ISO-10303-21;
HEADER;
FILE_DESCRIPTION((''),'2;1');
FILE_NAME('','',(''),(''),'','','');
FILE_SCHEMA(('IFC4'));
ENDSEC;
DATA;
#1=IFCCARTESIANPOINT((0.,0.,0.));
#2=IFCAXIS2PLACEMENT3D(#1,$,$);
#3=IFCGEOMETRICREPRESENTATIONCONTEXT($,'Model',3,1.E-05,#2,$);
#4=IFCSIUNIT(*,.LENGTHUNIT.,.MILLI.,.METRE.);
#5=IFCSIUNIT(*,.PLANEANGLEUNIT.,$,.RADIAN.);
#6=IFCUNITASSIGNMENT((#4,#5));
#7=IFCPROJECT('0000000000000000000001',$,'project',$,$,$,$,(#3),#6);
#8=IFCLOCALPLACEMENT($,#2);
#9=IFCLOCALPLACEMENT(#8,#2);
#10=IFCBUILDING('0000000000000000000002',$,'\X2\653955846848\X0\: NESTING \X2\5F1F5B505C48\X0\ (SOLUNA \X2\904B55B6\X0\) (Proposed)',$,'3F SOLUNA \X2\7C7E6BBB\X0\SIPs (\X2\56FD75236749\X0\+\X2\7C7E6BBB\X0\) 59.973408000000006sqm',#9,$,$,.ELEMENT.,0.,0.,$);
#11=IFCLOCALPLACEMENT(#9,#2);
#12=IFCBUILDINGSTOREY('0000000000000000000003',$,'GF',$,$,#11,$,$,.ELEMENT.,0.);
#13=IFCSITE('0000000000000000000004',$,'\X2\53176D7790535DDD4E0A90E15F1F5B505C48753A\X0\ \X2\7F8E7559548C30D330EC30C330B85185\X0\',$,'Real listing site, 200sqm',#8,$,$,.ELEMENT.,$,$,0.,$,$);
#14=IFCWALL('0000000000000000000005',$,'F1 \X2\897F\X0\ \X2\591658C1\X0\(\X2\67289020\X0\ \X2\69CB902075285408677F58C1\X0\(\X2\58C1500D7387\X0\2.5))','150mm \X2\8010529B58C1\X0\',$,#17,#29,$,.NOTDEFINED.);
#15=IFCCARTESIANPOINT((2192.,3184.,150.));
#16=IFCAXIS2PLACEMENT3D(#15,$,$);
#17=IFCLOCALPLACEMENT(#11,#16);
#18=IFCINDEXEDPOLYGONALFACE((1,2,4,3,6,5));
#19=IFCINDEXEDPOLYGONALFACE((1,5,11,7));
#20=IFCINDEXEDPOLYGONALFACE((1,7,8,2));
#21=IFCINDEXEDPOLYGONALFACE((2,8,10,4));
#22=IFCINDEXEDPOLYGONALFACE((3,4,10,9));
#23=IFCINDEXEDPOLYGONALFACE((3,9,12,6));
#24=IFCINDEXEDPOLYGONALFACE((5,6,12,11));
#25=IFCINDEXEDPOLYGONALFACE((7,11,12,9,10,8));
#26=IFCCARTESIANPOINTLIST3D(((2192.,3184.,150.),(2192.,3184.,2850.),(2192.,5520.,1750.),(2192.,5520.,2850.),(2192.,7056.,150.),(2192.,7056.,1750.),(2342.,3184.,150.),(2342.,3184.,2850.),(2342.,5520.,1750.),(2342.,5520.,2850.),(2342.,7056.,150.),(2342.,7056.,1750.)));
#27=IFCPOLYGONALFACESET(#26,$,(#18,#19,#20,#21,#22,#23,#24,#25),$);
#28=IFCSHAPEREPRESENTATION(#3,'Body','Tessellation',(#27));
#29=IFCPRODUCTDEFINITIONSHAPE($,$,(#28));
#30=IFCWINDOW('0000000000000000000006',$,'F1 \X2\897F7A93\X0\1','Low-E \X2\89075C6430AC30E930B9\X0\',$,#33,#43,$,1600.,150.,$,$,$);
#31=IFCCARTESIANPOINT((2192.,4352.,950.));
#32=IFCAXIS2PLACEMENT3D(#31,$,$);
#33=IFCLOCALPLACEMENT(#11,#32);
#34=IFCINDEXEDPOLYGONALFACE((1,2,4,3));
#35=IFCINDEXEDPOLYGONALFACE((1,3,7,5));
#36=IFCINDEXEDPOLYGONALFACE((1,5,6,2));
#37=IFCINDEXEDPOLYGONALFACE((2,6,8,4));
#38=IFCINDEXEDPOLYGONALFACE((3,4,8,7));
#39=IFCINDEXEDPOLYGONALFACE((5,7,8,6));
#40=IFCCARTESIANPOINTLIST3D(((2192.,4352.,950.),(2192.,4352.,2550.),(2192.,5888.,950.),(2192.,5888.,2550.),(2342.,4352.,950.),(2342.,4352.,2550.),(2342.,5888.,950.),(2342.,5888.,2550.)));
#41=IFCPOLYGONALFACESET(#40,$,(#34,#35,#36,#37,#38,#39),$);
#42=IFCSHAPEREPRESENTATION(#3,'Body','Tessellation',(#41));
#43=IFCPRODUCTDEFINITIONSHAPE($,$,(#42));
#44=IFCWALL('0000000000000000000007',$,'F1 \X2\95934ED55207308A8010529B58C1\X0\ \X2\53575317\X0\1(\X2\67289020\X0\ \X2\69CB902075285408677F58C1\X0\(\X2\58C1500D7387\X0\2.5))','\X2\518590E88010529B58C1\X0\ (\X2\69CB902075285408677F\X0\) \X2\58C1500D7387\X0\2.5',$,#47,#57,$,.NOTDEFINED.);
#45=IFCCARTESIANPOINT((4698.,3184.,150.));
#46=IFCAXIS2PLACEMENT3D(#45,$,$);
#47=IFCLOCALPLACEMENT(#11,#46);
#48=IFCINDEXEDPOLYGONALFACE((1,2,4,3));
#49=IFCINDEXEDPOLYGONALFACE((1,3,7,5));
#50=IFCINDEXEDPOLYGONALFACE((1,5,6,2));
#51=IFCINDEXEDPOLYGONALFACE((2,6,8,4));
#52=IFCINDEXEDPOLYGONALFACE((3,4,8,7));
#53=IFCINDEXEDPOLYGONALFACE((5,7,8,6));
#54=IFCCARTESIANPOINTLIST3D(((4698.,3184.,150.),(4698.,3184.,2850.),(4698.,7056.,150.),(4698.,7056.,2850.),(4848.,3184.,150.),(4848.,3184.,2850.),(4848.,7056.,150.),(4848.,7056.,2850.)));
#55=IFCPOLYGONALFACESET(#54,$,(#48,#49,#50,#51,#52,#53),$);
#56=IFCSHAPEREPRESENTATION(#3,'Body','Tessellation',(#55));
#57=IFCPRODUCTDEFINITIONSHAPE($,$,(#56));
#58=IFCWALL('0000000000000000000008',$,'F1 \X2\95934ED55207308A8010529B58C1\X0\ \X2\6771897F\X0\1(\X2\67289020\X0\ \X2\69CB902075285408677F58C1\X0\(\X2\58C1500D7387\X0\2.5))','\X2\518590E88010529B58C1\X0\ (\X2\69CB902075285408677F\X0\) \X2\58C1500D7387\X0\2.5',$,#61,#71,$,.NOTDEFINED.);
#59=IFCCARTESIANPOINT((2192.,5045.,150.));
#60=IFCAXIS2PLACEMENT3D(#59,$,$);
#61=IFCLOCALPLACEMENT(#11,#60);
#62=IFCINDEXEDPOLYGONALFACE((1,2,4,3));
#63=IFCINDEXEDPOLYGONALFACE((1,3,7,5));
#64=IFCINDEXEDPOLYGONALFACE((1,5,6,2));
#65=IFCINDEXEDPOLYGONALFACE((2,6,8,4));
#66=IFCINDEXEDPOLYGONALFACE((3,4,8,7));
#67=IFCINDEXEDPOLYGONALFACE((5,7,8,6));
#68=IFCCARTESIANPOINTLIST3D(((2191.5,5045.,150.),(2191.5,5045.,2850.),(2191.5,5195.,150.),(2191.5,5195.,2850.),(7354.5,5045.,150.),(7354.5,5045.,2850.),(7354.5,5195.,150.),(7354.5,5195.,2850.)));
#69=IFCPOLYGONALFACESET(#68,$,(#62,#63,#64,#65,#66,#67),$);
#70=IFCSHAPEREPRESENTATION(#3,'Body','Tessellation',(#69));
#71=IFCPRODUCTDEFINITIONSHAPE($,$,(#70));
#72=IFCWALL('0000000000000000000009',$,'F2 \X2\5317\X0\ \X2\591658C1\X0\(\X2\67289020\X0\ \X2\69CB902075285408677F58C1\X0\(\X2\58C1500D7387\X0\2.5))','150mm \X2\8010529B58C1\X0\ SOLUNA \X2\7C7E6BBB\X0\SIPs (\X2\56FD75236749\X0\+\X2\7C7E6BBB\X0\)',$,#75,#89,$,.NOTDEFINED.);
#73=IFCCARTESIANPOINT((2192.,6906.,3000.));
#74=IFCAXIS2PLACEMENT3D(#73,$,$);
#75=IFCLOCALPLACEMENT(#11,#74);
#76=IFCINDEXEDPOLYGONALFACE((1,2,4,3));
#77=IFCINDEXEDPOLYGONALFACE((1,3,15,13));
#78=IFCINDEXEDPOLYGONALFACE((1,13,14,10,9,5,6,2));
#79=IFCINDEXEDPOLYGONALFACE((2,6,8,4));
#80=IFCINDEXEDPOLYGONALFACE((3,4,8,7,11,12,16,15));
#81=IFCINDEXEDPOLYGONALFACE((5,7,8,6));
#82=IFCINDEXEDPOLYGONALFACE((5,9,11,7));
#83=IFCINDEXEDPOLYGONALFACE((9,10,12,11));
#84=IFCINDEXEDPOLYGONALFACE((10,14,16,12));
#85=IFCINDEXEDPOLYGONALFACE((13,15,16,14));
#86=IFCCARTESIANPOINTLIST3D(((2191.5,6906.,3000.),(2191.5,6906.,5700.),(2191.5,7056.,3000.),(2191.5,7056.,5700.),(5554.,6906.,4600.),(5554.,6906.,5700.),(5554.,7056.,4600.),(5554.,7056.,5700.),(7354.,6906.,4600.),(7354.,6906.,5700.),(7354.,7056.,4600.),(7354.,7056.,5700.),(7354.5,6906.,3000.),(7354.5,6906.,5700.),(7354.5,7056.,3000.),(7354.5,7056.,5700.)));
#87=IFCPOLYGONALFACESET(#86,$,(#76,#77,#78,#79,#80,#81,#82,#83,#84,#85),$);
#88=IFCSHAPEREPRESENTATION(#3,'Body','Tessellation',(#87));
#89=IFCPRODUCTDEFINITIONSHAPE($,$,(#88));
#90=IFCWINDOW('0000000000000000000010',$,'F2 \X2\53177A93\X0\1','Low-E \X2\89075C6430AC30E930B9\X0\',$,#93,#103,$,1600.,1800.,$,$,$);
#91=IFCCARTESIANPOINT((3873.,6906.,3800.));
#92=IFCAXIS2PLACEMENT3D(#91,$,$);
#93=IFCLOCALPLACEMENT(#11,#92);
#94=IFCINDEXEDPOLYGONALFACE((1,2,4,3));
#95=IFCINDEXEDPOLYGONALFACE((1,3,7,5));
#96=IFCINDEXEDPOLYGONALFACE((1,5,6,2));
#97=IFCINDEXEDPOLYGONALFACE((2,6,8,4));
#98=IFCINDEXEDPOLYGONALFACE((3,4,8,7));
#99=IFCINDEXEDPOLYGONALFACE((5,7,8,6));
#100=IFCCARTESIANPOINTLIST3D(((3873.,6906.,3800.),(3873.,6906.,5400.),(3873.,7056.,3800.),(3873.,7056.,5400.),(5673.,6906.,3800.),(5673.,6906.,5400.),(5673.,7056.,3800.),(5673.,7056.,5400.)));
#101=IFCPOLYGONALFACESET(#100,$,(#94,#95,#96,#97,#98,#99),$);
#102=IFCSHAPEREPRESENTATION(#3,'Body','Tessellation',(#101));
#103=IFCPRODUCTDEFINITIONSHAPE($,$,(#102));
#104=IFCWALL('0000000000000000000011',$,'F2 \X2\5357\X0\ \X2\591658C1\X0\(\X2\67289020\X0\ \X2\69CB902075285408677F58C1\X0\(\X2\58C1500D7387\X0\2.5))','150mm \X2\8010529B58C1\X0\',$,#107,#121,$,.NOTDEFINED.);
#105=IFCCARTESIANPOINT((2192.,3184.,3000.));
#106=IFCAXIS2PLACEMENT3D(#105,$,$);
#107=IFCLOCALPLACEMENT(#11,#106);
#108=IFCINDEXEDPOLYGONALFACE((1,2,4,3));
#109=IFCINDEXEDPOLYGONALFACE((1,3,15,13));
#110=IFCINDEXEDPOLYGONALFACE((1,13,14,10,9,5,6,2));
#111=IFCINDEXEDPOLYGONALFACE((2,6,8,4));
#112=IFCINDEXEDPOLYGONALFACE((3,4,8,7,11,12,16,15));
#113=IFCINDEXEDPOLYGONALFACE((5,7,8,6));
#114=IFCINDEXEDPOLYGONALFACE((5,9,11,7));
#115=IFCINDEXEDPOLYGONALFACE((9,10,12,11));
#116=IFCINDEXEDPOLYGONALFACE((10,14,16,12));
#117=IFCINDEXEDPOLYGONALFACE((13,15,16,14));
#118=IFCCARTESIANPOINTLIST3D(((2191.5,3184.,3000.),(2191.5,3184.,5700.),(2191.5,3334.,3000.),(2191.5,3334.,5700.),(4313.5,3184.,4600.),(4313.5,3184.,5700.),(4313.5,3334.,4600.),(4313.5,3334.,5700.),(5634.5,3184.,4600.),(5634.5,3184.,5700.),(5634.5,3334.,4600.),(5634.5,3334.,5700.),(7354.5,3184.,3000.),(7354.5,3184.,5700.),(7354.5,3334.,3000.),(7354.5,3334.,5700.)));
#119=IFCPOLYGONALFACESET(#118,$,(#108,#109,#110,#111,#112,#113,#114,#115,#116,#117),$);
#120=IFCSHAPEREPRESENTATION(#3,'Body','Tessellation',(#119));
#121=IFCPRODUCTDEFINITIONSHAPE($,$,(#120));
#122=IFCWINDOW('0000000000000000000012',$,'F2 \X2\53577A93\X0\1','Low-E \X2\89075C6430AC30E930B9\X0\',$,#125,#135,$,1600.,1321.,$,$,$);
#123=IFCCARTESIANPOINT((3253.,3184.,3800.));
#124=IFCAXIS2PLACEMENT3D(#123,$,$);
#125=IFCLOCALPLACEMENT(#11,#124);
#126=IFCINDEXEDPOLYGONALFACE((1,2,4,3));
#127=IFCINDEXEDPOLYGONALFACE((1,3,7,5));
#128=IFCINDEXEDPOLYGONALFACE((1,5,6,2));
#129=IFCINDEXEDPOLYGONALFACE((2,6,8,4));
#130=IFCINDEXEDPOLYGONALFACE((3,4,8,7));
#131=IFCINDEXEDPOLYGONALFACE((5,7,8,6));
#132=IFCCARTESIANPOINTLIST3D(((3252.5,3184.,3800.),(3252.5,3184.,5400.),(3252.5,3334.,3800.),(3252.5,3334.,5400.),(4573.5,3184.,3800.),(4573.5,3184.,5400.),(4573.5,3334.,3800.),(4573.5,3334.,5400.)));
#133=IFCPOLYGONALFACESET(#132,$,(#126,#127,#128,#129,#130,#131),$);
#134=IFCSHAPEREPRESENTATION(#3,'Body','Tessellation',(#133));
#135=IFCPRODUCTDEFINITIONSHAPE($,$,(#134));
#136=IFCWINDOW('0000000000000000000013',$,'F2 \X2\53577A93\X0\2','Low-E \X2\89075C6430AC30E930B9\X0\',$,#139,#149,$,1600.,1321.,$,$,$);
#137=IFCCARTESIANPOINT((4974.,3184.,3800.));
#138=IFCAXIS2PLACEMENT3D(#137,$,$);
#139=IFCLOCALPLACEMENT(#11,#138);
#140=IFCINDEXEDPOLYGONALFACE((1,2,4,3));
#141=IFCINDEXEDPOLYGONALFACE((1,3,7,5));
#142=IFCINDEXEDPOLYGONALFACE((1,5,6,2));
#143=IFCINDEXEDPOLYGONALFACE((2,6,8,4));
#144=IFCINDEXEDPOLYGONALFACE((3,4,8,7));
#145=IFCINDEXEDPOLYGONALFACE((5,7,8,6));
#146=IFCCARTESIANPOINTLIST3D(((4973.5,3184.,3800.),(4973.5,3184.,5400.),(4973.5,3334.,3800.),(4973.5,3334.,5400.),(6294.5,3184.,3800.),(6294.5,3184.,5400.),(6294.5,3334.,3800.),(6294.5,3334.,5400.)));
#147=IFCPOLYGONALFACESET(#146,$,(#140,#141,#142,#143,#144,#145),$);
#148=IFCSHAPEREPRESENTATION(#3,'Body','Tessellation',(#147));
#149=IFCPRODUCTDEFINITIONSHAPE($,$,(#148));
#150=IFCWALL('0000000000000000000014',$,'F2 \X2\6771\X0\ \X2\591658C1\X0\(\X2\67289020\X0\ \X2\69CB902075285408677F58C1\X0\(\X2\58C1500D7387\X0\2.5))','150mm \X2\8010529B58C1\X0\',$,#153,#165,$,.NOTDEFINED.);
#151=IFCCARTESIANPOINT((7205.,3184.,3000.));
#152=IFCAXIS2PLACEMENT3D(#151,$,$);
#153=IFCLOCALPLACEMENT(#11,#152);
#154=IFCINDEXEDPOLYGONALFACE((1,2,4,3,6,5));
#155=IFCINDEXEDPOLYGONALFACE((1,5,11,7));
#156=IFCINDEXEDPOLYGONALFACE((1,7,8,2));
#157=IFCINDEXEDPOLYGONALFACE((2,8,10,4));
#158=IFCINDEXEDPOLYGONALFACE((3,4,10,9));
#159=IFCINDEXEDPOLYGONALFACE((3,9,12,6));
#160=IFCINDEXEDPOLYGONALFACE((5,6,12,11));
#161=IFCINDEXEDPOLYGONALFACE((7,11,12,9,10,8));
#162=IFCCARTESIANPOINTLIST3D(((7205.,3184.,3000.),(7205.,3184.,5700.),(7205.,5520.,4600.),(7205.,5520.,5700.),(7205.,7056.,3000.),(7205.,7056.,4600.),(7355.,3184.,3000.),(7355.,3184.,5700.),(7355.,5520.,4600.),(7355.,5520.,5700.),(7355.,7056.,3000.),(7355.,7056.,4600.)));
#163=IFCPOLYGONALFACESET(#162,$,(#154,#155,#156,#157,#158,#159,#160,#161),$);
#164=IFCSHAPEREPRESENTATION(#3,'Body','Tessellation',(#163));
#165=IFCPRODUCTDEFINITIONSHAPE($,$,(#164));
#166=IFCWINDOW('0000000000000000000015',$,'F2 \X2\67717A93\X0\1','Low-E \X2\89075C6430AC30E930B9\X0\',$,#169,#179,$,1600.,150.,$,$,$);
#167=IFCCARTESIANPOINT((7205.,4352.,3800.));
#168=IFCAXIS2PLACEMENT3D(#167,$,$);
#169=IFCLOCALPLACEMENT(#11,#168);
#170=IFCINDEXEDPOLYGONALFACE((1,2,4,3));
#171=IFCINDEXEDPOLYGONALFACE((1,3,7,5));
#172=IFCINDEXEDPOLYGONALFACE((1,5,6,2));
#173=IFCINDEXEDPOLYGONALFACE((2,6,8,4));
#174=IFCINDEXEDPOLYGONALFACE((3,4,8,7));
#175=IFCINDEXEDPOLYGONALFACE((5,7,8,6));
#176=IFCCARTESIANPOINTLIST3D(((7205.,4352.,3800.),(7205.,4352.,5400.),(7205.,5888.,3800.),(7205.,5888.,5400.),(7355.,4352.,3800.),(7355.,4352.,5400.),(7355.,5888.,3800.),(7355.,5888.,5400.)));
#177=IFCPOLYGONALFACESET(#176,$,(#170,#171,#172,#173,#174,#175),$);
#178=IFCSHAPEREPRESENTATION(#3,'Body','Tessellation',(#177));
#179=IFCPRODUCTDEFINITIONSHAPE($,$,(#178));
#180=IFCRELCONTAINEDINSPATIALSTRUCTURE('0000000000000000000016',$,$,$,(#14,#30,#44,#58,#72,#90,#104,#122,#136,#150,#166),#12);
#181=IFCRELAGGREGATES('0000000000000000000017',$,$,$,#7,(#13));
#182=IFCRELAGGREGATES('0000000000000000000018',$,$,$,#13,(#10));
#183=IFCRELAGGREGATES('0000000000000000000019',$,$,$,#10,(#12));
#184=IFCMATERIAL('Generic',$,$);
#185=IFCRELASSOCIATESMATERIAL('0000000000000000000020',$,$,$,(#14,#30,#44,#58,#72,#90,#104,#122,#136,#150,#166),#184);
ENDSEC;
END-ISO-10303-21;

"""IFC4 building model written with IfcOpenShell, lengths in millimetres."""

from ifc_helpers import new_model, si_unit, frame, frame_2d, origin, place, context, project, spatial, rectangle, extrude, material, element, fill, save


model = new_model("IFC4")

# Units and contexts
model_context = context("Model", 3, precision=1e-05, world=origin())
ifc_project = project(units=[si_unit("LENGTHUNIT", "METRE", prefix="MILLI"), si_unit("PLANEANGLEUNIT", "RADIAN")], contexts=[model_context])

# Site, building, storey
site_placement = place(None, origin())
site = spatial("IfcSite", under=ifc_project, at=site_placement, Name="北海道川上郡弟子屈町 美留和ビレッジ内", ObjectType="Real listing site, 200sqm", CompositionType="ELEMENT", RefElevation=0.0)
building_placement = place(site_placement, origin())
building = spatial("IfcBuilding", under=site, at=building_placement, Name="改善案: NESTING 弟子屈 (SOLUNA 運営) (Proposed)", ObjectType="3F SOLUNA 籾殻SIPs (国産杉+籾殻) 59.973408000000006sqm", CompositionType="ELEMENT", ElevationOfRefHeight=0.0, ElevationOfTerrain=0.0)
storey_placement = place(building_placement, origin())
storey = spatial("IfcBuildingStorey", under=building, at=storey_placement, Name="GF", CompositionType="ELEMENT", Elevation=0.0)

# Shared definitions
ifc_material_1 = material(Name="Generic")

# Wall, opening, window
wall_1_placement = place(storey_placement, frame((2192.0, 3184.0, 150.0)))
wall_1 = element("IfcWall", 1, at=wall_1_placement, inside=storey, material=ifc_material_1, Name="F1 西 外壁(木造 構造用合板壁(壁倍率2.5))", Description="150mm 耐力壁", PredefinedType="NOTDEFINED", context=model_context, shape_type="SweptSolid", body=[
    extrude(rectangle(XDim=150.0, YDim=3872.0, at=frame_2d((75.0, 1936.0))), frame((2192.0, 3184.0, 150.0)), (0.0, 0.0, 1.0), 2700.0),
])
opening_1_placement = place(storey_placement, frame((2192.0, 4352.0, 950.0)))
opening_1 = element("IfcOpeningElement", 2, at=opening_1_placement, cuts=wall_1, PredefinedType="NOTDEFINED", context=model_context, shape_type="SweptSolid", body=[
    extrude(rectangle(XDim=150.0, YDim=1536.0, at=frame_2d((75.0, 768.0))), frame((2192.0, 4352.0, 950.0)), (0.0, 0.0, 1.0), 1600.0),
])
window_1_placement = place(storey_placement, frame((2192.0, 4352.0, 950.0)))
window_1 = element("IfcWindow", 3, at=window_1_placement, inside=storey, material=ifc_material_1, Name="F1 西窓1", Description="Low-E 複層ガラス", OverallHeight=1600.0, OverallWidth=150.0, context=model_context, shape_type="SweptSolid", body=[
    extrude(rectangle(XDim=150.0, YDim=1536.0, at=frame_2d((75.0, 768.0))), frame((2192.0, 4352.0, 950.0)), (0.0, 0.0, 1.0), 1600.0),
])
fill(opening_1, window_1)

# Walls
wall_2_placement = place(storey_placement, frame((4698.0, 3184.0, 150.0)))
element("IfcWall", 4, at=wall_2_placement, inside=storey, material=ifc_material_1, Name="F1 間仕切り耐力壁 南北1(木造 構造用合板壁(壁倍率2.5))", Description="内部耐力壁 (構造用合板) 壁倍率2.5", PredefinedType="NOTDEFINED", context=model_context, shape_type="SweptSolid", body=[
    extrude(rectangle(XDim=150.0, YDim=3872.0, at=frame_2d((75.0, 1936.0))), frame((4698.0, 3184.0, 150.0)), (0.0, 0.0, 1.0), 2700.0),
])
wall_3_placement = place(storey_placement, frame((2192.0, 5045.0, 150.0)))
element("IfcWall", 5, at=wall_3_placement, inside=storey, material=ifc_material_1, Name="F1 間仕切り耐力壁 東西1(木造 構造用合板壁(壁倍率2.5))", Description="内部耐力壁 (構造用合板) 壁倍率2.5", PredefinedType="NOTDEFINED", context=model_context, shape_type="SweptSolid", body=[
    extrude(rectangle(XDim=5163.0, YDim=150.0, at=frame_2d((2581.0, 75.0))), frame((2192.0, 5045.0, 150.0)), (0.0, 0.0, 1.0), 2700.0),
])

# Wall, opening, window
wall_4_placement = place(storey_placement, frame((2192.0, 6906.0, 3000.0)))
wall_4 = element("IfcWall", 6, at=wall_4_placement, inside=storey, material=ifc_material_1, Name="F2 北 外壁(木造 構造用合板壁(壁倍率2.5))", Description="150mm 耐力壁 SOLUNA 籾殻SIPs (国産杉+籾殻)", PredefinedType="NOTDEFINED", context=model_context, shape_type="SweptSolid", body=[
    extrude(rectangle(XDim=5163.0, YDim=150.0, at=frame_2d((2581.0, 75.0))), frame((2192.0, 6906.0, 3000.0)), (0.0, 0.0, 1.0), 2700.0),
])
opening_2_placement = place(storey_placement, frame((3873.0, 6906.0, 3800.0)))
opening_2 = element("IfcOpeningElement", 7, at=opening_2_placement, cuts=wall_4, PredefinedType="NOTDEFINED", context=model_context, shape_type="SweptSolid", body=[
    extrude(rectangle(XDim=1800.0, YDim=150.0, at=frame_2d((900.0, 75.0))), frame((3873.0, 6906.0, 3800.0)), (0.0, 0.0, 1.0), 1600.0),
])
window_2_placement = place(storey_placement, frame((3873.0, 6906.0, 3800.0)))
window_2 = element("IfcWindow", 8, at=window_2_placement, inside=storey, material=ifc_material_1, Name="F2 北窓1", Description="Low-E 複層ガラス", OverallHeight=1600.0, OverallWidth=1800.0, context=model_context, shape_type="SweptSolid", body=[
    extrude(rectangle(XDim=1800.0, YDim=150.0, at=frame_2d((900.0, 75.0))), frame((3873.0, 6906.0, 3800.0)), (0.0, 0.0, 1.0), 1600.0),
])
fill(opening_2, window_2)

# Wall, openings, windows
wall_5_placement = place(storey_placement, frame((2192.0, 3184.0, 3000.0)))
wall_5 = element("IfcWall", 9, at=wall_5_placement, inside=storey, material=ifc_material_1, Name="F2 南 外壁(木造 構造用合板壁(壁倍率2.5))", Description="150mm 耐力壁", PredefinedType="NOTDEFINED", context=model_context, shape_type="SweptSolid", body=[
    extrude(rectangle(XDim=5163.0, YDim=150.0, at=frame_2d((2581.0, 75.0))), frame((2192.0, 3184.0, 3000.0)), (0.0, 0.0, 1.0), 2700.0),
])
opening_3_placement = place(storey_placement, frame((3253.0, 3184.0, 3800.0)))
opening_3 = element("IfcOpeningElement", 10, at=opening_3_placement, cuts=wall_5, PredefinedType="NOTDEFINED", context=model_context, shape_type="SweptSolid", body=[
    extrude(rectangle(XDim=1321.0, YDim=150.0, at=frame_2d((660.0, 75.0))), frame((3253.0, 3184.0, 3800.0)), (0.0, 0.0, 1.0), 1600.0),
])
opening_4_placement = place(storey_placement, frame((4974.0, 3184.0, 3800.0)))
opening_4 = element("IfcOpeningElement", 11, at=opening_4_placement, cuts=wall_5, PredefinedType="NOTDEFINED", context=model_context, shape_type="SweptSolid", body=[
    extrude(rectangle(XDim=1321.0, YDim=150.0, at=frame_2d((660.0, 75.0))), frame((4974.0, 3184.0, 3800.0)), (0.0, 0.0, 1.0), 1600.0),
])
window_3_placement = place(storey_placement, frame((3253.0, 3184.0, 3800.0)))
window_3 = element("IfcWindow", 12, at=window_3_placement, inside=storey, material=ifc_material_1, Name="F2 南窓1", Description="Low-E 複層ガラス", OverallHeight=1600.0, OverallWidth=1321.0, context=model_context, shape_type="SweptSolid", body=[
    extrude(rectangle(XDim=1321.0, YDim=150.0, at=frame_2d((660.0, 75.0))), frame((3253.0, 3184.0, 3800.0)), (0.0, 0.0, 1.0), 1600.0),
])
fill(opening_3, window_3)
window_4_placement = place(storey_placement, frame((4974.0, 3184.0, 3800.0)))
window_4 = element("IfcWindow", 13, at=window_4_placement, inside=storey, material=ifc_material_1, Name="F2 南窓2", Description="Low-E 複層ガラス", OverallHeight=1600.0, OverallWidth=1321.0, context=model_context, shape_type="SweptSolid", body=[
    extrude(rectangle(XDim=1321.0, YDim=150.0, at=frame_2d((660.0, 75.0))), frame((4974.0, 3184.0, 3800.0)), (0.0, 0.0, 1.0), 1600.0),
])
fill(opening_4, window_4)

# Wall, opening, window
wall_6_placement = place(storey_placement, frame((7205.0, 3184.0, 3000.0)))
wall_6 = element("IfcWall", 14, at=wall_6_placement, inside=storey, material=ifc_material_1, Name="F2 東 外壁(木造 構造用合板壁(壁倍率2.5))", Description="150mm 耐力壁", PredefinedType="NOTDEFINED", context=model_context, shape_type="SweptSolid", body=[
    extrude(rectangle(XDim=150.0, YDim=3872.0, at=frame_2d((75.0, 1936.0))), frame((7205.0, 3184.0, 3000.0)), (0.0, 0.0, 1.0), 2700.0),
])
opening_5_placement = place(storey_placement, frame((7205.0, 4352.0, 3800.0)))
opening_5 = element("IfcOpeningElement", 15, at=opening_5_placement, cuts=wall_6, PredefinedType="NOTDEFINED", context=model_context, shape_type="SweptSolid", body=[
    extrude(rectangle(XDim=150.0, YDim=1536.0, at=frame_2d((75.0, 768.0))), frame((7205.0, 4352.0, 3800.0)), (0.0, 0.0, 1.0), 1600.0),
])
window_5_placement = place(storey_placement, frame((7205.0, 4352.0, 3800.0)))
window_5 = element("IfcWindow", 16, at=window_5_placement, inside=storey, material=ifc_material_1, Name="F2 東窓1", Description="Low-E 複層ガラス", OverallHeight=1600.0, OverallWidth=150.0, context=model_context, shape_type="SweptSolid", body=[
    extrude(rectangle(XDim=150.0, YDim=1536.0, at=frame_2d((75.0, 768.0))), frame((7205.0, 4352.0, 3800.0)), (0.0, 0.0, 1.0), 1600.0),
])
fill(opening_5, window_5)

save(model, "model.ifc")
